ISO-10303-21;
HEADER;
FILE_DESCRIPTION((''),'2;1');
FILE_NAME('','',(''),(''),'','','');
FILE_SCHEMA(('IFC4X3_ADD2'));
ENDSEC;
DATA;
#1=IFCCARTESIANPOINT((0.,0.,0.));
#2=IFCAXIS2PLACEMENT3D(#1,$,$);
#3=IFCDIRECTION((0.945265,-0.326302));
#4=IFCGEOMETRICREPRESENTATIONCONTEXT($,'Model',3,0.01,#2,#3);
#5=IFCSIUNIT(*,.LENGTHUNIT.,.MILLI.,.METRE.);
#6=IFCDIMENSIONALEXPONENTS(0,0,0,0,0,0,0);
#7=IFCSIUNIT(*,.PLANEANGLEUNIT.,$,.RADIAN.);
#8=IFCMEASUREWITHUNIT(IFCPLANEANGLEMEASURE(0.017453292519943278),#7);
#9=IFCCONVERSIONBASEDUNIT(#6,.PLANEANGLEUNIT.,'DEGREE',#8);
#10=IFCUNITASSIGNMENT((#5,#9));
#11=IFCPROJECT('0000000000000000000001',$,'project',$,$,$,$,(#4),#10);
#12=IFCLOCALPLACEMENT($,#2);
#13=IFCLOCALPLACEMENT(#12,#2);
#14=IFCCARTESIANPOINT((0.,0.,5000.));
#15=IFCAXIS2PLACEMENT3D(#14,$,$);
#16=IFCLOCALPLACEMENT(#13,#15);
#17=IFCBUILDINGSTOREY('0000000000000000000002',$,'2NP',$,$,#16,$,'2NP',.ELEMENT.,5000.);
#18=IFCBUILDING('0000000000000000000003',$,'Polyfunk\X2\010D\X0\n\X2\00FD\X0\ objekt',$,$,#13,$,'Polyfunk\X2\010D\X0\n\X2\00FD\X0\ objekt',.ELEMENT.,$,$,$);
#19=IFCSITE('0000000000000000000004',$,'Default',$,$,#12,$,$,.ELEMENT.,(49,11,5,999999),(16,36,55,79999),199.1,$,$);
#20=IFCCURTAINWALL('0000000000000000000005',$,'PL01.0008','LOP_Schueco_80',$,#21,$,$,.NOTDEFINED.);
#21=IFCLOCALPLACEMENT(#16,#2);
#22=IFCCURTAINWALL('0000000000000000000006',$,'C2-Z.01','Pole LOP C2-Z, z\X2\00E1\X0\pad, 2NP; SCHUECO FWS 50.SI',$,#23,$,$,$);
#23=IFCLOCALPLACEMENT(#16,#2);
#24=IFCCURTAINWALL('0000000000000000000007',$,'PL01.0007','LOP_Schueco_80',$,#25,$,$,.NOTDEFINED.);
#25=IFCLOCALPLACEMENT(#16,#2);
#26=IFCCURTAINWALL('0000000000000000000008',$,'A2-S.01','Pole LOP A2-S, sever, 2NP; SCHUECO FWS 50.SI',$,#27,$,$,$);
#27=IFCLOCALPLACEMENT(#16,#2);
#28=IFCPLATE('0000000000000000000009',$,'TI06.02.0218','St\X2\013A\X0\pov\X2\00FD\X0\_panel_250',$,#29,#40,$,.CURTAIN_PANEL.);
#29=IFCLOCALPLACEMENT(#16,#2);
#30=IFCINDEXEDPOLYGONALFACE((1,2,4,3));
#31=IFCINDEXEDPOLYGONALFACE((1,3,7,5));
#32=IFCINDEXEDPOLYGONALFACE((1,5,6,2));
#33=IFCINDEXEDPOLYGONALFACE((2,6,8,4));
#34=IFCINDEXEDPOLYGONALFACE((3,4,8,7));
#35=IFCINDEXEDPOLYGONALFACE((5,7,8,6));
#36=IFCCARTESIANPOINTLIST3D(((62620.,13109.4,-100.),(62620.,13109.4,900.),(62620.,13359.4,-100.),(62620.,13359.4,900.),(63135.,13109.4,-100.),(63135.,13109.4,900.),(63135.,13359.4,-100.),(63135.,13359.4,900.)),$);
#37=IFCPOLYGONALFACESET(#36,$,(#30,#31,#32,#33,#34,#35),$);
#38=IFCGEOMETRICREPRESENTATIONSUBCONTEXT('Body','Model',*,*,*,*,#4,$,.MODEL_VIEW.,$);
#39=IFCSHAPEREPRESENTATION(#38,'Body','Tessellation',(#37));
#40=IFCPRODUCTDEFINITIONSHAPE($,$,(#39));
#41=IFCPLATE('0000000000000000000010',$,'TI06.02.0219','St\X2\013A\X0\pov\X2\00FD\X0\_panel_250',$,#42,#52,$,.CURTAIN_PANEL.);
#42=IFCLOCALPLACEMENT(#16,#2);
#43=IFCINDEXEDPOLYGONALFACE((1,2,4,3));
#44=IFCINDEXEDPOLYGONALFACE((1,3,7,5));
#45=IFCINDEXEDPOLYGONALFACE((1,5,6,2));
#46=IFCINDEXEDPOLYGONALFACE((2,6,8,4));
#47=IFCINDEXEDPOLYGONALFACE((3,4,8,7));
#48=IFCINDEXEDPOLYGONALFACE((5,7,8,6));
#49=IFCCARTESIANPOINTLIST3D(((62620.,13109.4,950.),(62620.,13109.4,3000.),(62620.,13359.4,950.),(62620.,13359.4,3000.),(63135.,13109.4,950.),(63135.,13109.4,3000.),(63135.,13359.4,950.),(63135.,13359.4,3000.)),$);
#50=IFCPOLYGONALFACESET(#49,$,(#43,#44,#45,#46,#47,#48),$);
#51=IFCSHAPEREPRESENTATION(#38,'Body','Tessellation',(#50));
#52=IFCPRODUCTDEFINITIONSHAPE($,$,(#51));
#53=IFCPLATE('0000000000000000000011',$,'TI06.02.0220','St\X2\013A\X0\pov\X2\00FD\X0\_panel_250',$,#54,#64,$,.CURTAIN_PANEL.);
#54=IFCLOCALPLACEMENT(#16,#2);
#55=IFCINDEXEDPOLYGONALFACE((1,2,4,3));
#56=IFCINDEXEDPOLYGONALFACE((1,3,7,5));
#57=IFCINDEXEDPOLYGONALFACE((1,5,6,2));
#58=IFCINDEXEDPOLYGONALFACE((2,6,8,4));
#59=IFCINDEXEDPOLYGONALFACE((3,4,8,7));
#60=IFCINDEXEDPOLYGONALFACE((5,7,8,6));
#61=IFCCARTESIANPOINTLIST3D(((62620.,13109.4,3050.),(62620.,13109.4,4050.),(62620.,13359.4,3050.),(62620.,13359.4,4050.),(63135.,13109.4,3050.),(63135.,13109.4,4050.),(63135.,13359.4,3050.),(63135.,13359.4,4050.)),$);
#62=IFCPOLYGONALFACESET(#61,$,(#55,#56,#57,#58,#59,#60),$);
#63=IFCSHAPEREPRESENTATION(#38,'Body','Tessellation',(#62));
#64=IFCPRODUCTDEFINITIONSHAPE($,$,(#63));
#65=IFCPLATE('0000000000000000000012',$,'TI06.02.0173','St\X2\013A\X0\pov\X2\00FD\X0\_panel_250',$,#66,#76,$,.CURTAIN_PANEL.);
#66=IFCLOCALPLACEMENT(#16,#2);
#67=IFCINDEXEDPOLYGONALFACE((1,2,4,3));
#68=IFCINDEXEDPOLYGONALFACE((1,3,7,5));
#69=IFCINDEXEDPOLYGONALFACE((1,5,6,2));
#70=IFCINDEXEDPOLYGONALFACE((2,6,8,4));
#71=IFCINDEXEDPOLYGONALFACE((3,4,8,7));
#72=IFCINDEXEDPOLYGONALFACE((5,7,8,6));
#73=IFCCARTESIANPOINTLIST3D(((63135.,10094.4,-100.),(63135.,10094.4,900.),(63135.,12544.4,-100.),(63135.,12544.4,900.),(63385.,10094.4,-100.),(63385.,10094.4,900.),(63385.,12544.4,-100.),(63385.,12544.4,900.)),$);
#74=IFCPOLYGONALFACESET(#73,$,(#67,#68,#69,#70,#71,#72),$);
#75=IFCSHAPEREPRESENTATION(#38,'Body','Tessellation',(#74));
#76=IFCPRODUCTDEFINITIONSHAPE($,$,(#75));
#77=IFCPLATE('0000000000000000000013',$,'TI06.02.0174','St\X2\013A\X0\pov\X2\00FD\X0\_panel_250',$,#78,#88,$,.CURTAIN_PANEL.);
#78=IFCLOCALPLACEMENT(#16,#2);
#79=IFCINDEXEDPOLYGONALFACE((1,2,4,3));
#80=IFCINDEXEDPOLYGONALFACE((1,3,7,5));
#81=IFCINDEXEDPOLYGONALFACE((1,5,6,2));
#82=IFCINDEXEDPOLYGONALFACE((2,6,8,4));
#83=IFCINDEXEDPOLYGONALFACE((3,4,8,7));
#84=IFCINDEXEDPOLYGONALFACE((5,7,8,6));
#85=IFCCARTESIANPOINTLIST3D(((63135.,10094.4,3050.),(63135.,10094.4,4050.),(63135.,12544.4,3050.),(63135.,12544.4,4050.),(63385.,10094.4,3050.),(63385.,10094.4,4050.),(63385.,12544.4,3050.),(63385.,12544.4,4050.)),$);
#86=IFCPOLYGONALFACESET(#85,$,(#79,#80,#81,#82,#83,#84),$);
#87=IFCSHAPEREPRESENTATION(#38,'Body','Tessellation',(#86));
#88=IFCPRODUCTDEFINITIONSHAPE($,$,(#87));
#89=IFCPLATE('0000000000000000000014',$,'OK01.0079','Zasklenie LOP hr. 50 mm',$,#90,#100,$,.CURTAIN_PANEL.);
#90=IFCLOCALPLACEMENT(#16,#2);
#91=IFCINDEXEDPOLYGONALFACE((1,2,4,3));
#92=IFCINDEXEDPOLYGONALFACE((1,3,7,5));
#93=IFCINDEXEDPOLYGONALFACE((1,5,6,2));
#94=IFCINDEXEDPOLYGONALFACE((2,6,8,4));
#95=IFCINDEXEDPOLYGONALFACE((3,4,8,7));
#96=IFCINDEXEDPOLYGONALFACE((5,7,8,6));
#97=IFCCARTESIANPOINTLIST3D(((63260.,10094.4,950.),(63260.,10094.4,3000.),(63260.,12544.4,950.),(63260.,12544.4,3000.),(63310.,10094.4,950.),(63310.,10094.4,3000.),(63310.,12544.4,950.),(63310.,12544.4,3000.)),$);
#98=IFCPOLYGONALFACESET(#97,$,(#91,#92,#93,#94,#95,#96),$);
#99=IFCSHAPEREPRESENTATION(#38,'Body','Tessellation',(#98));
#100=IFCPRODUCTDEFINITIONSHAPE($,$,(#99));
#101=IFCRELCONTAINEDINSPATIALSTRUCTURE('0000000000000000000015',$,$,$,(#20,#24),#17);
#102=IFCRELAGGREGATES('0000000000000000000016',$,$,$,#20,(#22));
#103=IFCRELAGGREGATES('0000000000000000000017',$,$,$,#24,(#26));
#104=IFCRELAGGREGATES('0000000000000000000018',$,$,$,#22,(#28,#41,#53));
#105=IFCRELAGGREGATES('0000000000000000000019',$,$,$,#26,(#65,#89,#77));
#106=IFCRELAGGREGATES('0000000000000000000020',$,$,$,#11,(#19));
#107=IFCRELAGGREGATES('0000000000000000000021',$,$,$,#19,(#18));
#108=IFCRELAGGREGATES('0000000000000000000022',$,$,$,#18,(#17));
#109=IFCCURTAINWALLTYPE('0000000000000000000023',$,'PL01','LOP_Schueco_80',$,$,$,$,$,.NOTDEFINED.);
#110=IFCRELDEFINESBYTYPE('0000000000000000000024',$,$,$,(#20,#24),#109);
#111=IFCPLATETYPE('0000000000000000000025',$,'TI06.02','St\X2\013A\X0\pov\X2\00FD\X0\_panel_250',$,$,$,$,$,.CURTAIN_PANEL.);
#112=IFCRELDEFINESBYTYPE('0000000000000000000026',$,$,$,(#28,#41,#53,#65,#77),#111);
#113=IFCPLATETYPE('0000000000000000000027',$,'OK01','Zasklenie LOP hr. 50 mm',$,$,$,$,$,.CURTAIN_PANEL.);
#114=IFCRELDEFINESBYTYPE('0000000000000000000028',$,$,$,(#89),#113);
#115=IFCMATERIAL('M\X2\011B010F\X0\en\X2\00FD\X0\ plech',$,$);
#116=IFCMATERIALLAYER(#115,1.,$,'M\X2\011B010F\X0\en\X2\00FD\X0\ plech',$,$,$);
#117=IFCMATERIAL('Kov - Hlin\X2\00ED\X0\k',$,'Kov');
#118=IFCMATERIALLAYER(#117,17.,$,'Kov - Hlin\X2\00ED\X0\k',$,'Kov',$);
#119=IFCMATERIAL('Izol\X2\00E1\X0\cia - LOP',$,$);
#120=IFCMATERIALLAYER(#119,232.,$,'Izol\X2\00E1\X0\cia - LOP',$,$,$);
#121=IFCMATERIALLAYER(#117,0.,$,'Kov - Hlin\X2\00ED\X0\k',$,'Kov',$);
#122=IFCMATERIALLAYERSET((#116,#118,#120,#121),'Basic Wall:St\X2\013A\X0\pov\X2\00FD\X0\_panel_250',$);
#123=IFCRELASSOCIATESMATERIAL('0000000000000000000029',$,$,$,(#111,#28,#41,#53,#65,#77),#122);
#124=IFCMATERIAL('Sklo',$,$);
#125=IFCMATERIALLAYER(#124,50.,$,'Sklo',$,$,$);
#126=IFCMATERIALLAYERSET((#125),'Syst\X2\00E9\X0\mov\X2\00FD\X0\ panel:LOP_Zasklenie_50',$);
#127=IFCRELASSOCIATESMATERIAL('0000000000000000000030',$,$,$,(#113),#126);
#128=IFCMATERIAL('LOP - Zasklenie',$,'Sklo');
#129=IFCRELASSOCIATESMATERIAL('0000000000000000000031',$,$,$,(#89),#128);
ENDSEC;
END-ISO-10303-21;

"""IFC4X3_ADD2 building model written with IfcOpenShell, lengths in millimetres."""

from ifc_helpers import new_model, entity, si_unit, converted_unit, direction, frame, frame_2d, origin, origin_2d_with_axis, place, context, subcontext, project, spatial, rectangle, extrude, source, transform, mapped, material, layer, layer_set, layer_usage, type_object, type_shapes, element, aggregate, save


model = new_model("IFC4X3_ADD2")

# Units and contexts
model_context = context("Model", 3, precision=0.01, world=origin(), true_north=direction((0.945265, -0.326302)))
body_context = subcontext(model_context, "Body", "Model", "MODEL_VIEW")
ifc_project = project(units=[si_unit("LENGTHUNIT", "METRE", prefix="MILLI"), converted_unit("PLANEANGLEUNIT", "DEGREE", entity("IfcPlaneAngleMeasure", 0.017453292519943278), si_unit("PLANEANGLEUNIT", "RADIAN"), dimensions=[0, 0, 0, 0, 0, 0, 0])], contexts=[model_context])

# Site, building, storey
site_placement = place(None, origin())
site = spatial("IfcSite", under=ifc_project, at=site_placement, Name="Default", CompositionType="ELEMENT", RefLatitude=(49, 11, 5, 999999), RefLongitude=(16, 36, 55, 79999), RefElevation=199.1)
building_placement = place(site_placement, origin())
building = spatial("IfcBuilding", under=site, at=building_placement, Name="Polyfunkčný objekt", LongName="Polyfunkčný objekt", CompositionType="ELEMENT")
storey_placement = place(building_placement, frame((0.0, 0.0, 5000.0)))
storey = spatial("IfcBuildingStorey", under=building, at=storey_placement, Name="2NP", LongName="2NP", CompositionType="ELEMENT", Elevation=5000.0)

# Curtain walls
curtain_wall_type = type_object("IfcCurtainWallType", Name="PL01", Description="LOP_Schueco_80", PredefinedType="NOTDEFINED")
curtain_wall_1_placement = place(storey_placement, frame((0.0, 0.0, -5000.0)))
curtain_wall_1 = element("IfcCurtainWall", 1, at=curtain_wall_1_placement, inside=storey, type_object=curtain_wall_type, Name="PL01.0008", Description="LOP_Schueco_80", PredefinedType="NOTDEFINED")
curtain_wall_2 = element("IfcCurtainWall", 2, Name="C2-Z.01", Description="Pole LOP C2-Z, západ, 2NP; SCHUECO FWS 50.SI")
aggregate(curtain_wall_1, [curtain_wall_2])
curtain_wall_3_placement = place(storey_placement, frame((0.0, 0.0, -5000.0)))
curtain_wall_3 = element("IfcCurtainWall", 3, at=curtain_wall_3_placement, inside=storey, type_object=curtain_wall_type, Name="PL01.0007", Description="LOP_Schueco_80", PredefinedType="NOTDEFINED")
curtain_wall_4 = element("IfcCurtainWall", 4, Name="A2-S.01", Description="Pole LOP A2-S, sever, 2NP; SCHUECO FWS 50.SI")
aggregate(curtain_wall_3, [curtain_wall_4])

# Plates
ifc_material_1 = material(Name="Měďený plech")
ifc_layer_1 = layer(ifc_material_1, 1.0, Name="Měďený plech")
ifc_material_2 = material(Name="Kov - Hliník", Category="Kov")
ifc_layer_2 = layer(ifc_material_2, 17.0, Name="Kov - Hliník", Category="Kov")
ifc_material_3 = material(Name="Izolácia - LOP")
ifc_layer_3 = layer(ifc_material_3, 232.0, Name="Izolácia - LOP")
ifc_layer_4 = layer(ifc_material_2, 0.0, Name="Kov - Hliník", Category="Kov")
ifc_layer_set_1 = layer_set([ifc_layer_1, ifc_layer_2, ifc_layer_3, ifc_layer_4], Name="Basic Wall:Stĺpový_panel_250")
ifc_layer_usage_1 = layer_usage(ifc_layer_set_1, "AXIS2", "NEGATIVE", 125.0)
plate_type_1 = type_object("IfcPlateType", Name="TI06.02", Description="Stĺpový_panel_250", PredefinedType="CURTAIN_PANEL", material=ifc_layer_set_1)
plate_1_placement = place(storey_placement, frame((62620.0, 13234.4, -100.0)))
plate_1 = element("IfcPlate", 5, at=plate_1_placement, type_object=plate_type_1, material=ifc_layer_usage_1, Name="TI06.02.0218", Description="Stĺpový_panel_250", PredefinedType="CURTAIN_PANEL", context=body_context, shape_type="SweptSolid", body=[
    extrude(rectangle(XDim=250.0, YDim=515.0, at=frame_2d((0.0, 0.0), x_axis=(1.0, 0.0))), frame((257.5, 0.0, 0.0), z_axis=(0.0, 0.0, 1.0), x_axis=(0.0, 1.0, 0.0)), (0.0, 0.0, 1.0), 1000.0),
])
ifc_layer_usage_2 = layer_usage(ifc_layer_set_1, "AXIS2", "NEGATIVE", 125.0)
plate_2_placement = place(storey_placement, frame((62620.0, 13234.4, 950.0)))
plate_2 = element("IfcPlate", 6, at=plate_2_placement, type_object=plate_type_1, material=ifc_layer_usage_2, Name="TI06.02.0219", Description="Stĺpový_panel_250", PredefinedType="CURTAIN_PANEL", context=body_context, shape_type="SweptSolid", body=[
    extrude(rectangle(XDim=250.0, YDim=515.0, at=frame_2d((0.0, 0.0), x_axis=(1.0, 0.0))), frame((257.5, 0.0, 0.0), z_axis=(0.0, 0.0, 1.0), x_axis=(0.0, 1.0, 0.0)), (0.0, 0.0, 1.0), 2050.0),
])
ifc_layer_usage_3 = layer_usage(ifc_layer_set_1, "AXIS2", "NEGATIVE", 125.0)
plate_3_placement = place(storey_placement, frame((62620.0, 13234.4, 3050.0)))
plate_3 = element("IfcPlate", 7, at=plate_3_placement, type_object=plate_type_1, material=ifc_layer_usage_3, Name="TI06.02.0220", Description="Stĺpový_panel_250", PredefinedType="CURTAIN_PANEL", context=body_context, shape_type="SweptSolid", body=[
    extrude(rectangle(XDim=250.0, YDim=515.0, at=frame_2d((0.0, 0.0), x_axis=(1.0, 0.0))), frame((257.5, 0.0, 0.0), z_axis=(0.0, 0.0, 1.0), x_axis=(0.0, 1.0, 0.0)), (0.0, 0.0, 1.0), 1000.0),
])
aggregate(curtain_wall_2, [plate_1, plate_2, plate_3])
ifc_layer_usage_4 = layer_usage(ifc_layer_set_1, "AXIS2", "NEGATIVE", 125.0)
plate_4_placement = place(storey_placement, frame((63260.0, 12544.4, -100.0), z_axis=(0.0, 0.0, 1.0), x_axis=(0.0, -1.0, 0.0)))
plate_4 = element("IfcPlate", 8, at=plate_4_placement, type_object=plate_type_1, material=ifc_layer_usage_4, Name="TI06.02.0173", Description="Stĺpový_panel_250", PredefinedType="CURTAIN_PANEL", context=body_context, shape_type="SweptSolid", body=[
    extrude(rectangle(XDim=250.0, YDim=2450.0, at=frame_2d((0.0, 0.0), x_axis=(1.0, 0.0))), frame((1225.0, 0.0, 0.0), z_axis=(0.0, 0.0, 1.0), x_axis=(0.0, 1.0, 0.0)), (0.0, 0.0, 1.0), 1000.0),
])
ifc_layer_usage_5 = layer_usage(ifc_layer_set_1, "AXIS2", "NEGATIVE", 125.0)
plate_5_placement = place(storey_placement, frame((63260.0, 12544.4, 3050.0), z_axis=(0.0, 0.0, 1.0), x_axis=(0.0, -1.0, 0.0)))
plate_5 = element("IfcPlate", 9, at=plate_5_placement, type_object=plate_type_1, material=ifc_layer_usage_5, Name="TI06.02.0174", Description="Stĺpový_panel_250", PredefinedType="CURTAIN_PANEL", context=body_context, shape_type="SweptSolid", body=[
    extrude(rectangle(XDim=250.0, YDim=2450.0, at=frame_2d((0.0, 0.0), x_axis=(1.0, 0.0))), frame((1225.0, 0.0, 0.0), z_axis=(0.0, 0.0, 1.0), x_axis=(0.0, 1.0, 0.0)), (0.0, 0.0, 1.0), 1000.0),
])
ifc_material_4 = material(Name="LOP - Zasklenie", Category="Sklo")
ifc_material_5 = material(Name="Sklo")
ifc_layer_5 = layer(ifc_material_5, 50.0, Name="Sklo")
ifc_layer_set_2 = layer_set([ifc_layer_5], Name="Systémový panel:LOP_Zasklenie_50")
plate_type_2 = type_object("IfcPlateType", Name="OK01", Description="Zasklenie LOP hr. 50 mm", PredefinedType="CURTAIN_PANEL", material=ifc_layer_set_2)
shared_shape_1 = source(origin(), body_context, "Body", "SweptSolid", [
    extrude(rectangle(XDim=50.0, YDim=2450.0, at=origin_2d_with_axis()), frame((0.0, 25.0, 0.0), z_axis=(0.0, 0.0, 1.0), x_axis=(0.0, 1.0, 0.0)), (0.0, 0.0, 1.0), 2050.0),
])
type_shapes(plate_type_2, [shared_shape_1])
plate_6_placement = place(curtain_wall_3_placement, frame((63260.0, 11319.4, 5950.0), z_axis=(0.0, 0.0, 1.0), x_axis=(0.0, -1.0, 0.0)))
plate_6 = element("IfcPlate", 10, at=plate_6_placement, type_object=plate_type_2, material=ifc_material_4, Name="OK01.0079", Description="Zasklenie LOP hr. 50 mm", PredefinedType="CURTAIN_PANEL", context=body_context, shape_type="MappedRepresentation", body=[
    mapped(shared_shape_1, transform((0.0, 0.0, 0.0), scale=1.0)),
])
aggregate(curtain_wall_4, [plate_4, plate_6, plate_5])

save(model, "model.ifc")
